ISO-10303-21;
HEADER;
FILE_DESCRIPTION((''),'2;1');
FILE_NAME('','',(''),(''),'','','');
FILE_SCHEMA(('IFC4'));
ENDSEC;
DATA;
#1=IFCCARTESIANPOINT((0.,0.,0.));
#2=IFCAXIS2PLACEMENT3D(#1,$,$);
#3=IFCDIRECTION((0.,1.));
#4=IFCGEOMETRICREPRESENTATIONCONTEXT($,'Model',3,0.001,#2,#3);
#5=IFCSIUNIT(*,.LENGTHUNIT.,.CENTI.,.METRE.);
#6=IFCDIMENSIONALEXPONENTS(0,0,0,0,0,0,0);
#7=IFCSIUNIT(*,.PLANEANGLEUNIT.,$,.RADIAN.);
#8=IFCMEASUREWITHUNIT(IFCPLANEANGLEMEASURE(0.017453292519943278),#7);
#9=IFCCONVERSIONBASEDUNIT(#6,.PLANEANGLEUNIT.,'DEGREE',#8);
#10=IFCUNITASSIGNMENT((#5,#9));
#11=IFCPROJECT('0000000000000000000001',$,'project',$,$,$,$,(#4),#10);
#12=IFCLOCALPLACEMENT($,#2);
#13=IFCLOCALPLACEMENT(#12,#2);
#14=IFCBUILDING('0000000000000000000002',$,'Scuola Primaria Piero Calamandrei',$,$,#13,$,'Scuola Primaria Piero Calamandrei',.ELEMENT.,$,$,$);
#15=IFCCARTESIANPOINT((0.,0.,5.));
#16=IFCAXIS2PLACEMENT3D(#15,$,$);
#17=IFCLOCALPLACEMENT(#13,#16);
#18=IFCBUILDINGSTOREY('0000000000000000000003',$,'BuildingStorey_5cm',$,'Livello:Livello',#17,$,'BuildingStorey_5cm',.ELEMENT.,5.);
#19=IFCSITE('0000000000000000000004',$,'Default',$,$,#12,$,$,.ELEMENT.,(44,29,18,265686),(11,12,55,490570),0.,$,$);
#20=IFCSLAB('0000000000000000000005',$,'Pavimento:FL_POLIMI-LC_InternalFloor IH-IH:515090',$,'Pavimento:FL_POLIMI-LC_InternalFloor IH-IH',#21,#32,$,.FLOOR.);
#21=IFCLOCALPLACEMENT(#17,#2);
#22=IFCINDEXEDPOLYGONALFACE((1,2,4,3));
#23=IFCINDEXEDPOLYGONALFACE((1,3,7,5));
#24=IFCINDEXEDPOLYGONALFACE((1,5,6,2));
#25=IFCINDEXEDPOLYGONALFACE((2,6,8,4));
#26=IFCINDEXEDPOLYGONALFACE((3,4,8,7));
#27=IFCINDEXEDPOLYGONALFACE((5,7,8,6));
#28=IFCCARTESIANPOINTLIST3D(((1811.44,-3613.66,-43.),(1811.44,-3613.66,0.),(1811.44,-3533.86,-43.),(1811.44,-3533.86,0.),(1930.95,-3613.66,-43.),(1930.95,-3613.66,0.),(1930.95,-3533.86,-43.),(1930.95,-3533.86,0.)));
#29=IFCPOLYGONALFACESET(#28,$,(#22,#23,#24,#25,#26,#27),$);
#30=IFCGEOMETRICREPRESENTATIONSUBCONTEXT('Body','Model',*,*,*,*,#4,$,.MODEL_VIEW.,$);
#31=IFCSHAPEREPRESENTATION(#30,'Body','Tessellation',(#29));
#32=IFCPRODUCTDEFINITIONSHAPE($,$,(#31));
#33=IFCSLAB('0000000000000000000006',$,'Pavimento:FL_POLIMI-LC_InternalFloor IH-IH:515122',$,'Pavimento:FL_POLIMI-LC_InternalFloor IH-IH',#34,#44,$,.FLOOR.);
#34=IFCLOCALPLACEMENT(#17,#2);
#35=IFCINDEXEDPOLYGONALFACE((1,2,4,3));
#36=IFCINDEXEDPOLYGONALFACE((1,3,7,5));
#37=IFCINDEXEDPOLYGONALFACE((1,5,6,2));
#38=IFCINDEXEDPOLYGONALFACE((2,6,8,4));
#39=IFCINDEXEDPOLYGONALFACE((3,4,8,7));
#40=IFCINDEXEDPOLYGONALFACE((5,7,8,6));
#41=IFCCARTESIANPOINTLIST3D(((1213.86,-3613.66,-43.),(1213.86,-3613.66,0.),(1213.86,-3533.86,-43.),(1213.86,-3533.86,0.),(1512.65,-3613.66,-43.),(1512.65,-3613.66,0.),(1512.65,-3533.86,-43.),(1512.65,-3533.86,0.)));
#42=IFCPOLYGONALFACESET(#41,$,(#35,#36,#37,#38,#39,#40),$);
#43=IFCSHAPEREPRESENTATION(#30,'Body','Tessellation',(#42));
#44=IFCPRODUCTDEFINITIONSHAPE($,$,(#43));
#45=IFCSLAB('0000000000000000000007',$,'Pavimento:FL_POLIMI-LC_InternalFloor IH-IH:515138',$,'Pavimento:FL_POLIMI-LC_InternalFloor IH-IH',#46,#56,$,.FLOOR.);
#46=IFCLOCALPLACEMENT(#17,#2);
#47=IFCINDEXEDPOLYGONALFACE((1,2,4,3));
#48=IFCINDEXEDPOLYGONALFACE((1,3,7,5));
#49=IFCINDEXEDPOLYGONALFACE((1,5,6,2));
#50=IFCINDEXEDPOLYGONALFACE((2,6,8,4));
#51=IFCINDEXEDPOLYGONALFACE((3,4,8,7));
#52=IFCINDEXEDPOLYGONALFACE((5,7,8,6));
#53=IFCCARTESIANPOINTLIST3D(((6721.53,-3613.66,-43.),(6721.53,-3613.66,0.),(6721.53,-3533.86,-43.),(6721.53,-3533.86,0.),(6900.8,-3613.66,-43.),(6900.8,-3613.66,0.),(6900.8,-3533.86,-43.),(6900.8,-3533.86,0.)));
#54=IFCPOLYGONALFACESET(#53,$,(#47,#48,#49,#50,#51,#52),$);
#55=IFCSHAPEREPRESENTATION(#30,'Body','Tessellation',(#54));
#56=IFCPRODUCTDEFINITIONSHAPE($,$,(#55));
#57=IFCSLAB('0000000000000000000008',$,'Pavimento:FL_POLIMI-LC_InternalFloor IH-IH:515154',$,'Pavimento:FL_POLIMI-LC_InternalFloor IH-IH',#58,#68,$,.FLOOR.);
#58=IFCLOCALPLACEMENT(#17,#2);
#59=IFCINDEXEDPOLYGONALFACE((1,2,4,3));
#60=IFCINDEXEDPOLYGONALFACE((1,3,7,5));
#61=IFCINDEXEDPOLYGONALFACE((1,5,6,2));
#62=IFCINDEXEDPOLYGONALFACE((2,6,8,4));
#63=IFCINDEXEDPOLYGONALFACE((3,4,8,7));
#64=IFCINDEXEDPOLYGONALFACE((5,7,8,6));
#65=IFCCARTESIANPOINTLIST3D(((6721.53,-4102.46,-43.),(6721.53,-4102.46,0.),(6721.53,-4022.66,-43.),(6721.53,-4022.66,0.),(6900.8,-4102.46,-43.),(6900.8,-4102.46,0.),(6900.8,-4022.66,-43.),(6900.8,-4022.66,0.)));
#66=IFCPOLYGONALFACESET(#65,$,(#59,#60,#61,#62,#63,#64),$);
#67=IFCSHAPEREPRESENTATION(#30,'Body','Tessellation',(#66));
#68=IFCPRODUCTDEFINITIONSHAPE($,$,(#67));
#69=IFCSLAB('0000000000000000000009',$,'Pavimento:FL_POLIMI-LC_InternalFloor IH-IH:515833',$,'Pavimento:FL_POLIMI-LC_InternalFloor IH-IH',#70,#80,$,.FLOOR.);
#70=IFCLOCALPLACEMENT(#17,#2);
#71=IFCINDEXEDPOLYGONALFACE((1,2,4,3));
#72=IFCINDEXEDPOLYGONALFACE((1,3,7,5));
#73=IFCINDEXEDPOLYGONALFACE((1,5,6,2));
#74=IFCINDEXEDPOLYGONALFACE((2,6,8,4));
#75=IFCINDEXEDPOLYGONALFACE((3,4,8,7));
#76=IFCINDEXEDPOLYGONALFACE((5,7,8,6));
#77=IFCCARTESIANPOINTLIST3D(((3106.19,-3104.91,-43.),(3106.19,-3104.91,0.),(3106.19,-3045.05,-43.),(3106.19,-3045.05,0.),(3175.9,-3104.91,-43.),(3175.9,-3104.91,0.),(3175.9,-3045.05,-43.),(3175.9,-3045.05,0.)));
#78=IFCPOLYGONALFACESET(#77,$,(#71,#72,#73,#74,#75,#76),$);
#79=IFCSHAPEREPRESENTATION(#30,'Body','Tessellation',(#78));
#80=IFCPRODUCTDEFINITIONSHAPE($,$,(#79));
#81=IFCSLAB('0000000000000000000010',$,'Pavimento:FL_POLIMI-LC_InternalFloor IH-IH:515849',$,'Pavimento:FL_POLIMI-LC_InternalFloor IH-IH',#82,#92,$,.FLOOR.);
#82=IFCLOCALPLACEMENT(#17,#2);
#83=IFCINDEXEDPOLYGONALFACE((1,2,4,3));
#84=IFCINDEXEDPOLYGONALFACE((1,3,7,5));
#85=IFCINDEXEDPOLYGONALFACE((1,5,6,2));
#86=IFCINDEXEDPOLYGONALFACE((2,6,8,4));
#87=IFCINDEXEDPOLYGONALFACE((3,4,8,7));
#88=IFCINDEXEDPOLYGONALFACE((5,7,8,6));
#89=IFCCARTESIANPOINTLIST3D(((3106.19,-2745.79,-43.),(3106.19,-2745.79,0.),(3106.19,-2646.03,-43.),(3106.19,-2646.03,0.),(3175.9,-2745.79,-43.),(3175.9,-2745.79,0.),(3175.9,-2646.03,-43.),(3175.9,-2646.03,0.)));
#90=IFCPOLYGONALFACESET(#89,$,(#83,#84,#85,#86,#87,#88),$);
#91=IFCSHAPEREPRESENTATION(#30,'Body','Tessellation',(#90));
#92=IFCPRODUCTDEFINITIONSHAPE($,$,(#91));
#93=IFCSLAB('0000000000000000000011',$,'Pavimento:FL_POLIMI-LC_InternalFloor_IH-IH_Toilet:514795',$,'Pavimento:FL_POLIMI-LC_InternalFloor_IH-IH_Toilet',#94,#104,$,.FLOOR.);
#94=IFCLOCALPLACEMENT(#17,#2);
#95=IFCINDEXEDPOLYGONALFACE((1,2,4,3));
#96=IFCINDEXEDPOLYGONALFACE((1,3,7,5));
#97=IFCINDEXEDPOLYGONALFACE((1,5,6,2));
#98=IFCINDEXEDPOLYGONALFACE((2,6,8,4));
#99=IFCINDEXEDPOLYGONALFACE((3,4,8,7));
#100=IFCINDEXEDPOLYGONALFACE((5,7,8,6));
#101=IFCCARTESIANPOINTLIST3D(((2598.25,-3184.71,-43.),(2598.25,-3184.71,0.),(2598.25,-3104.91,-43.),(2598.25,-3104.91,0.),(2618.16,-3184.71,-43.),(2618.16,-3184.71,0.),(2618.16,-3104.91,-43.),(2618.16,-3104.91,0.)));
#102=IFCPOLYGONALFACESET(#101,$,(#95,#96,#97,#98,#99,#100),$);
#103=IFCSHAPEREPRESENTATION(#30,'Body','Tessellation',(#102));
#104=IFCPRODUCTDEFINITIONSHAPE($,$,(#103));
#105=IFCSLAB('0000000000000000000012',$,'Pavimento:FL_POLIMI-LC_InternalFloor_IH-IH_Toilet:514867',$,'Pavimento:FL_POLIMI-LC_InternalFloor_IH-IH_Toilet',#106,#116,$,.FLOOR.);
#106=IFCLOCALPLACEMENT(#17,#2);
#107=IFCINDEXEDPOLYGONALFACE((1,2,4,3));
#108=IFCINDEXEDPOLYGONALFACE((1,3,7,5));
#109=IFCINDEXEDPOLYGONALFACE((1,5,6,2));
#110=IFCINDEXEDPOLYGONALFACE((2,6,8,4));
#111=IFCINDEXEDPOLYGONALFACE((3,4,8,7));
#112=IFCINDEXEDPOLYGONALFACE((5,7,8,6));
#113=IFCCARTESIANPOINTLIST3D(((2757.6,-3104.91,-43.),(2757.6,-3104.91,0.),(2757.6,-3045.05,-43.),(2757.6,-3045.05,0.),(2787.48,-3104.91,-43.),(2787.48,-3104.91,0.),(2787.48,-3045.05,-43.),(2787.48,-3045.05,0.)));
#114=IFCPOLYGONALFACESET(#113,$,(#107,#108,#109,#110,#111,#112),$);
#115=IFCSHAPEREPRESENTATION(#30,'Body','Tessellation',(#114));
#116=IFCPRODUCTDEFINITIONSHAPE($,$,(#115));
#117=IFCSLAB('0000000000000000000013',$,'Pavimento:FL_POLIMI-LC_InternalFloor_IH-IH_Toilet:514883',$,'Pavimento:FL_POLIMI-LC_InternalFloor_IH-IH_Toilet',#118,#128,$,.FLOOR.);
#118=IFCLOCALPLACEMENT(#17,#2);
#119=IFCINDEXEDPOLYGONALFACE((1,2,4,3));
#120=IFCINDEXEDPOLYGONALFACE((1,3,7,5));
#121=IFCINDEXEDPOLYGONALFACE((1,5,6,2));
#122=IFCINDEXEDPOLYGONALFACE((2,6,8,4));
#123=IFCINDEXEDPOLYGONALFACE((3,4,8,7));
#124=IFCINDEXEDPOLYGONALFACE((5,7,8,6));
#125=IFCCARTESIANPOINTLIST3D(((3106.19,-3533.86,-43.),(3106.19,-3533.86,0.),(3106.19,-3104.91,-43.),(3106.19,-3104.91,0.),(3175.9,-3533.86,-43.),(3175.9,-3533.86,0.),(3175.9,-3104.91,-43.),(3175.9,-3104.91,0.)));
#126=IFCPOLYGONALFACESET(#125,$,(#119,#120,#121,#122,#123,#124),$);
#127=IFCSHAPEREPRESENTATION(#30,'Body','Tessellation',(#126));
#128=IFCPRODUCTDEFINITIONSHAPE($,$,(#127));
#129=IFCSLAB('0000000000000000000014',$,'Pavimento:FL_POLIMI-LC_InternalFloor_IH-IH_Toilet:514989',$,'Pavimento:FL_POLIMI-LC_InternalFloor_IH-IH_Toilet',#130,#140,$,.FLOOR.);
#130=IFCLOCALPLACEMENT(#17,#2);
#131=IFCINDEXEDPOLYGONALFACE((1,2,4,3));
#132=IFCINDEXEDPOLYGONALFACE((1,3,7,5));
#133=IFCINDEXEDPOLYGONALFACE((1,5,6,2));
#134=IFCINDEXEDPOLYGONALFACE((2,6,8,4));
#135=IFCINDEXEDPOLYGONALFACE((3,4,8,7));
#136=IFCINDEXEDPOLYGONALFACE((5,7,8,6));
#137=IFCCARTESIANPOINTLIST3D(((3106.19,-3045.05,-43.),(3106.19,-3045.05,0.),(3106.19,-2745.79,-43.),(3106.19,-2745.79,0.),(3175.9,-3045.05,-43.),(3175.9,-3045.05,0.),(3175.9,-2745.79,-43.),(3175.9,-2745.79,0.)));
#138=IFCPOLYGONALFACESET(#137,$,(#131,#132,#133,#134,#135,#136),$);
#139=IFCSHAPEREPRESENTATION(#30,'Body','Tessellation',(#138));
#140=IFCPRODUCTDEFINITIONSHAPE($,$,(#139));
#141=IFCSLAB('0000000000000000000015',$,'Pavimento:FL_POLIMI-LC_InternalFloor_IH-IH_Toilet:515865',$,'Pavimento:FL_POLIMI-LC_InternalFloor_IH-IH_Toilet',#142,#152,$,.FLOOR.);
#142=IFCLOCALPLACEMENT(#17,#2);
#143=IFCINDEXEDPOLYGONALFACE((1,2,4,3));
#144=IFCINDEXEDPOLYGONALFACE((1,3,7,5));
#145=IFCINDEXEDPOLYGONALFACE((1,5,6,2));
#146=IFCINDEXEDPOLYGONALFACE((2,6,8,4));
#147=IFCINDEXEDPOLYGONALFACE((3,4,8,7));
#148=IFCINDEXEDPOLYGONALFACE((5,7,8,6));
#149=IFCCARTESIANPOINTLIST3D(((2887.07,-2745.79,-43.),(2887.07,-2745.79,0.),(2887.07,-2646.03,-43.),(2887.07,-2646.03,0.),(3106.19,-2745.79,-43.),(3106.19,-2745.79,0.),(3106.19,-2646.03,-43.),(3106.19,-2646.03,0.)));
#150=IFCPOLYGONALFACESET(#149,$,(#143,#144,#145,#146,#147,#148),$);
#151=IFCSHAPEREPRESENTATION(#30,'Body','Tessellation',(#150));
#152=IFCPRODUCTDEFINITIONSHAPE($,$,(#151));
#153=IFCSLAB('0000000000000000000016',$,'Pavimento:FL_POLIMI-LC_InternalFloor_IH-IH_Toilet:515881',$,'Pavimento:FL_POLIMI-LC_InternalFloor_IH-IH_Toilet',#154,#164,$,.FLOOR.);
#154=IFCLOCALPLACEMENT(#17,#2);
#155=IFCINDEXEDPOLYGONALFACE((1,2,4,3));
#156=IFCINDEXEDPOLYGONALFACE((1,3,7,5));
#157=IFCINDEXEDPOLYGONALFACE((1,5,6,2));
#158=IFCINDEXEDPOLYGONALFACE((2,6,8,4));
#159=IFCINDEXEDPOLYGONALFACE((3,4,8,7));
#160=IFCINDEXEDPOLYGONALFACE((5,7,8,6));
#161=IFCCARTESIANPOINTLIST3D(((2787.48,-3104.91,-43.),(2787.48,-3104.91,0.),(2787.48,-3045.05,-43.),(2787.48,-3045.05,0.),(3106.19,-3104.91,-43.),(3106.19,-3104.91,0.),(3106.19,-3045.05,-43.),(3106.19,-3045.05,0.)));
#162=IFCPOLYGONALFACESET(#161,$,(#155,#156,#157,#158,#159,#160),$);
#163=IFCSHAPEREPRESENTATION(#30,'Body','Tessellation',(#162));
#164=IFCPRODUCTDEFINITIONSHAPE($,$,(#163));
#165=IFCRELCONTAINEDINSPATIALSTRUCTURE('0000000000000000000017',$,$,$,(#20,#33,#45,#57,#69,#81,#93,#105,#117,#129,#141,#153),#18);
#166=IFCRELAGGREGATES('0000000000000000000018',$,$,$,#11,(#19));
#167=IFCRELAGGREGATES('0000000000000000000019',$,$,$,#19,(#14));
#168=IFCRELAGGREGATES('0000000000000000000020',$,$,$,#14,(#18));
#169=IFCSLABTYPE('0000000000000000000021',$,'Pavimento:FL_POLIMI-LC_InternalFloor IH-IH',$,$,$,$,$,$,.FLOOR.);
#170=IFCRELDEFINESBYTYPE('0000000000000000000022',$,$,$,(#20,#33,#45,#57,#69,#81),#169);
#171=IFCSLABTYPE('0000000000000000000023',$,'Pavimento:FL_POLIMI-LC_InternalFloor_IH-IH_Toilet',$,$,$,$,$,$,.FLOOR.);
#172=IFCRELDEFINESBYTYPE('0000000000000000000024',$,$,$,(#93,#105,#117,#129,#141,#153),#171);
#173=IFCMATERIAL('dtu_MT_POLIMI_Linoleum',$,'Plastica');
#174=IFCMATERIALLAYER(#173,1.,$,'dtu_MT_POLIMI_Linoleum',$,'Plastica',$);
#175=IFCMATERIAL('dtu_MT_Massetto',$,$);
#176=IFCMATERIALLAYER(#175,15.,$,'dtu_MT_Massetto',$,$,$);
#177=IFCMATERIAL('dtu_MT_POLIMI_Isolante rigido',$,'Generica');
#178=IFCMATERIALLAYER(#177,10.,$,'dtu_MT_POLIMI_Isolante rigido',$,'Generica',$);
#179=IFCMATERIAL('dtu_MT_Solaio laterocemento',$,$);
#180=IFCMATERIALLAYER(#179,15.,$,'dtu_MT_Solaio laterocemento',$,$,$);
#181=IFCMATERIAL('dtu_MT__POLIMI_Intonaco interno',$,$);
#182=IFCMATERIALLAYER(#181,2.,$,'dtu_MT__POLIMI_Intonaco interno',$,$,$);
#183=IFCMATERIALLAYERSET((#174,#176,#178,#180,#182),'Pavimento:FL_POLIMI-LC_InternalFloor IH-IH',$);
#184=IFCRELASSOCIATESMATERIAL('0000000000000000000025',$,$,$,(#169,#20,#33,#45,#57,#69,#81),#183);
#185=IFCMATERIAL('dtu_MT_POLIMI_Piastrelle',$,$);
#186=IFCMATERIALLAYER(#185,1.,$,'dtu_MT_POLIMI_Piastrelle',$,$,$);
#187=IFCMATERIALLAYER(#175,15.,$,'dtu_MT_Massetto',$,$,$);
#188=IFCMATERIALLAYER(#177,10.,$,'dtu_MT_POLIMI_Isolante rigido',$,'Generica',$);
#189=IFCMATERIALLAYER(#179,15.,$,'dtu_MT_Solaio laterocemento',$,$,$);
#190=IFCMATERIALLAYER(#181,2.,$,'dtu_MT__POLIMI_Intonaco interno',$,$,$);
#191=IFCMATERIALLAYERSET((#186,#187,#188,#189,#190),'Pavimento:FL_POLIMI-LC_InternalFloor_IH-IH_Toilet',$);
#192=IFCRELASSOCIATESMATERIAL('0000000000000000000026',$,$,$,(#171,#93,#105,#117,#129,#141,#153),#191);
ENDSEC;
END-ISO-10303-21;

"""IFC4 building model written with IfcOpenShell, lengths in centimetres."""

from ifc_helpers import new_model, entity, si_unit, converted_unit, direction, frame, frame_2d, origin, origin_2d_with_axis, place, context, subcontext, project, spatial, rectangle, extrude, material, layer, layer_set, layer_usage, type_object, element, save


model = new_model("IFC4")

# Units and contexts
model_context = context("Model", 3, precision=0.001, world=origin(), true_north=direction((0.0, 1.0)))
body_context = subcontext(model_context, "Body", "Model", "MODEL_VIEW")
ifc_project = project(units=[si_unit("LENGTHUNIT", "METRE", prefix="CENTI"), converted_unit("PLANEANGLEUNIT", "DEGREE", entity("IfcPlaneAngleMeasure", 0.017453292519943278), si_unit("PLANEANGLEUNIT", "RADIAN"), dimensions=[0, 0, 0, 0, 0, 0, 0])], contexts=[model_context])

# Site, building, storey
site_placement = place(None, origin())
site = spatial("IfcSite", under=ifc_project, at=site_placement, Name="Default", CompositionType="ELEMENT", RefLatitude=(44, 29, 18, 265686), RefLongitude=(11, 12, 55, 490570), RefElevation=0.0)
building_placement = place(site_placement, origin())
building = spatial("IfcBuilding", under=site, at=building_placement, Name="Scuola Primaria Piero Calamandrei", LongName="Scuola Primaria Piero Calamandrei", CompositionType="ELEMENT")
storey_placement = place(building_placement, frame((0.0, 0.0, 5.0)))
storey = spatial("IfcBuildingStorey", under=building, at=storey_placement, Name="BuildingStorey_5cm", ObjectType="Livello:Livello", LongName="BuildingStorey_5cm", CompositionType="ELEMENT", Elevation=5.0)

# Slabs
ifc_material_1 = material(Name="dtu_MT_POLIMI_Linoleum", Category="Plastica")
ifc_layer_1 = layer(ifc_material_1, 1.0, Name="dtu_MT_POLIMI_Linoleum", Category="Plastica")
ifc_material_2 = material(Name="dtu_MT_Massetto")
ifc_layer_2 = layer(ifc_material_2, 15.0, Name="dtu_MT_Massetto")
ifc_material_3 = material(Name="dtu_MT_POLIMI_Isolante rigido", Category="Generica")
ifc_layer_3 = layer(ifc_material_3, 10.0, Name="dtu_MT_POLIMI_Isolante rigido", Category="Generica")
ifc_material_4 = material(Name="dtu_MT_Solaio laterocemento")
ifc_layer_4 = layer(ifc_material_4, 15.0, Name="dtu_MT_Solaio laterocemento")
ifc_material_5 = material(Name="dtu_MT__POLIMI_Intonaco interno")
ifc_layer_5 = layer(ifc_material_5, 2.0, Name="dtu_MT__POLIMI_Intonaco interno")
ifc_layer_set_1 = layer_set([ifc_layer_1, ifc_layer_2, ifc_layer_3, ifc_layer_4, ifc_layer_5], Name="Pavimento:FL_POLIMI-LC_InternalFloor IH-IH")
slab_type_1 = type_object("IfcSlabType", Name="Pavimento:FL_POLIMI-LC_InternalFloor IH-IH", PredefinedType="FLOOR", material=ifc_layer_set_1)
ifc_layer_usage_1 = layer_usage(ifc_layer_set_1, "AXIS3", "POSITIVE", 0.0)
slab_1_placement = place(storey_placement, origin())
element("IfcSlab", 1, at=slab_1_placement, inside=storey, type_object=slab_type_1, material=ifc_layer_usage_1, Name="Pavimento:FL_POLIMI-LC_InternalFloor IH-IH:515090", ObjectType="Pavimento:FL_POLIMI-LC_InternalFloor IH-IH", PredefinedType="FLOOR", context=body_context, shape_type="SweptSolid", body=[
    extrude(rectangle(XDim=79.8, YDim=119.52, at=origin_2d_with_axis()), frame((1871.19, -3573.76, 0.0), z_axis=(0.0, 0.0, -1.0), x_axis=(0.0, 1.0, 0.0)), (0.0, 0.0, 1.0), 43.0),
])
ifc_layer_usage_2 = layer_usage(ifc_layer_set_1, "AXIS3", "POSITIVE", 0.0)
slab_2_placement = place(storey_placement, origin())
element("IfcSlab", 2, at=slab_2_placement, inside=storey, type_object=slab_type_1, material=ifc_layer_usage_2, Name="Pavimento:FL_POLIMI-LC_InternalFloor IH-IH:515122", ObjectType="Pavimento:FL_POLIMI-LC_InternalFloor IH-IH", PredefinedType="FLOOR", context=body_context, shape_type="SweptSolid", body=[
    extrude(rectangle(XDim=79.8, YDim=298.79, at=frame_2d((0.0, 0.0), x_axis=(1.0, 0.0))), frame((1363.25, -3573.76, 0.0), z_axis=(0.0, 0.0, -1.0), x_axis=(0.0, 1.0, 0.0)), (0.0, 0.0, 1.0), 43.0),
])
ifc_layer_usage_3 = layer_usage(ifc_layer_set_1, "AXIS3", "POSITIVE", 0.0)
slab_3_placement = place(storey_placement, origin())
element("IfcSlab", 3, at=slab_3_placement, inside=storey, type_object=slab_type_1, material=ifc_layer_usage_3, Name="Pavimento:FL_POLIMI-LC_InternalFloor IH-IH:515138", ObjectType="Pavimento:FL_POLIMI-LC_InternalFloor IH-IH", PredefinedType="FLOOR", context=body_context, shape_type="SweptSolid", body=[
    extrude(rectangle(XDim=79.8, YDim=179.27, at=frame_2d((0.0, 0.0), x_axis=(1.0, 0.0))), frame((6811.16, -3573.76, 0.0), z_axis=(0.0, 0.0, -1.0), x_axis=(0.0, 1.0, 0.0)), (0.0, 0.0, 1.0), 43.0),
])
ifc_layer_usage_4 = layer_usage(ifc_layer_set_1, "AXIS3", "POSITIVE", 0.0)
slab_4_placement = place(storey_placement, origin())
element("IfcSlab", 4, at=slab_4_placement, inside=storey, type_object=slab_type_1, material=ifc_layer_usage_4, Name="Pavimento:FL_POLIMI-LC_InternalFloor IH-IH:515154", ObjectType="Pavimento:FL_POLIMI-LC_InternalFloor IH-IH", PredefinedType="FLOOR", context=body_context, shape_type="SweptSolid", body=[
    extrude(rectangle(XDim=79.8, YDim=179.27, at=frame_2d((0.0, 0.0), x_axis=(1.0, 0.0))), frame((6811.16, -4062.56, 0.0), z_axis=(0.0, 0.0, -1.0), x_axis=(0.0, 1.0, 0.0)), (0.0, 0.0, 1.0), 43.0),
])
ifc_layer_usage_5 = layer_usage(ifc_layer_set_1, "AXIS3", "POSITIVE", 0.0)
slab_5_placement = place(storey_placement, origin())
element("IfcSlab", 5, at=slab_5_placement, inside=storey, type_object=slab_type_1, material=ifc_layer_usage_5, Name="Pavimento:FL_POLIMI-LC_InternalFloor IH-IH:515833", ObjectType="Pavimento:FL_POLIMI-LC_InternalFloor IH-IH", PredefinedType="FLOOR", context=body_context, shape_type="SweptSolid", body=[
    extrude(rectangle(XDim=59.85, YDim=69.72, at=frame_2d((0.0, 0.0), x_axis=(1.0, 0.0))), frame((3141.04, -3074.98, 0.0), z_axis=(0.0, 0.0, -1.0), x_axis=(0.0, 1.0, 0.0)), (0.0, 0.0, 1.0), 43.0),
])
ifc_layer_usage_6 = layer_usage(ifc_layer_set_1, "AXIS3", "POSITIVE", 0.0)
slab_6_placement = place(storey_placement, origin())
element("IfcSlab", 6, at=slab_6_placement, inside=storey, type_object=slab_type_1, material=ifc_layer_usage_6, Name="Pavimento:FL_POLIMI-LC_InternalFloor IH-IH:515849", ObjectType="Pavimento:FL_POLIMI-LC_InternalFloor IH-IH", PredefinedType="FLOOR", context=body_context, shape_type="SweptSolid", body=[
    extrude(rectangle(XDim=99.76, YDim=69.72, at=origin_2d_with_axis()), frame((3141.04, -2695.91, 0.0), z_axis=(0.0, 0.0, -1.0), x_axis=(0.0, 1.0, 0.0)), (0.0, 0.0, 1.0), 43.0),
])
ifc_material_6 = material(Name="dtu_MT_POLIMI_Piastrelle")
ifc_layer_6 = layer(ifc_material_6, 1.0, Name="dtu_MT_POLIMI_Piastrelle")
ifc_layer_7 = layer(ifc_material_2, 15.0, Name="dtu_MT_Massetto")
ifc_layer_8 = layer(ifc_material_3, 10.0, Name="dtu_MT_POLIMI_Isolante rigido", Category="Generica")
ifc_layer_9 = layer(ifc_material_4, 15.0, Name="dtu_MT_Solaio laterocemento")
ifc_layer_10 = layer(ifc_material_5, 2.0, Name="dtu_MT__POLIMI_Intonaco interno")
ifc_layer_set_2 = layer_set([ifc_layer_6, ifc_layer_7, ifc_layer_8, ifc_layer_9, ifc_layer_10], Name="Pavimento:FL_POLIMI-LC_InternalFloor_IH-IH_Toilet")
ifc_layer_usage_7 = layer_usage(ifc_layer_set_2, "AXIS3", "POSITIVE", 0.0)
slab_type_2 = type_object("IfcSlabType", Name="Pavimento:FL_POLIMI-LC_InternalFloor_IH-IH_Toilet", PredefinedType="FLOOR", material=ifc_layer_set_2)
slab_7_placement = place(storey_placement, origin())
element("IfcSlab", 7, at=slab_7_placement, inside=storey, type_object=slab_type_2, material=ifc_layer_usage_7, Name="Pavimento:FL_POLIMI-LC_InternalFloor_IH-IH_Toilet:514795", ObjectType="Pavimento:FL_POLIMI-LC_InternalFloor_IH-IH_Toilet", PredefinedType="FLOOR", context=body_context, shape_type="SweptSolid", body=[
    extrude(rectangle(XDim=79.8, YDim=19.92, at=frame_2d((0.0, 0.0), x_axis=(1.0, 0.0))), frame((2608.21, -3144.81, 0.0), z_axis=(0.0, 0.0, -1.0), x_axis=(0.0, 1.0, 0.0)), (0.0, 0.0, 1.0), 43.0),
])
ifc_layer_usage_8 = layer_usage(ifc_layer_set_2, "AXIS3", "POSITIVE", 0.0)
slab_8_placement = place(storey_placement, origin())
element("IfcSlab", 8, at=slab_8_placement, inside=storey, type_object=slab_type_2, material=ifc_layer_usage_8, Name="Pavimento:FL_POLIMI-LC_InternalFloor_IH-IH_Toilet:514867", ObjectType="Pavimento:FL_POLIMI-LC_InternalFloor_IH-IH_Toilet", PredefinedType="FLOOR", context=body_context, shape_type="SweptSolid", body=[
    extrude(rectangle(XDim=59.85, YDim=29.88, at=frame_2d((0.0, 0.0), x_axis=(1.0, 0.0))), frame((2772.54, -3074.98, 0.0), z_axis=(0.0, 0.0, -1.0), x_axis=(0.0, 1.0, 0.0)), (0.0, 0.0, 1.0), 43.0),
])
ifc_layer_usage_9 = layer_usage(ifc_layer_set_2, "AXIS3", "POSITIVE", 0.0)
slab_9_placement = place(storey_placement, origin())
element("IfcSlab", 9, at=slab_9_placement, inside=storey, type_object=slab_type_2, material=ifc_layer_usage_9, Name="Pavimento:FL_POLIMI-LC_InternalFloor_IH-IH_Toilet:514883", ObjectType="Pavimento:FL_POLIMI-LC_InternalFloor_IH-IH_Toilet", PredefinedType="FLOOR", context=body_context, shape_type="SweptSolid", body=[
    extrude(rectangle(XDim=428.95, YDim=69.72, at=frame_2d((0.0, 0.0), x_axis=(1.0, 0.0))), frame((3141.04, -3319.38, 0.0), z_axis=(0.0, 0.0, -1.0), x_axis=(0.0, 1.0, 0.0)), (0.0, 0.0, 1.0), 43.0),
])
ifc_layer_usage_10 = layer_usage(ifc_layer_set_2, "AXIS3", "POSITIVE", 0.0)
slab_10_placement = place(storey_placement, origin())
element("IfcSlab", 10, at=slab_10_placement, inside=storey, type_object=slab_type_2, material=ifc_layer_usage_10, Name="Pavimento:FL_POLIMI-LC_InternalFloor_IH-IH_Toilet:514989", ObjectType="Pavimento:FL_POLIMI-LC_InternalFloor_IH-IH_Toilet", PredefinedType="FLOOR", context=body_context, shape_type="SweptSolid", body=[
    extrude(rectangle(XDim=299.27, YDim=69.72, at=frame_2d((0.0, 0.0), x_axis=(1.0, 0.0))), frame((3141.04, -2895.42, 0.0), z_axis=(0.0, 0.0, -1.0), x_axis=(0.0, 1.0, 0.0)), (0.0, 0.0, 1.0), 43.0),
])
ifc_layer_usage_11 = layer_usage(ifc_layer_set_2, "AXIS3", "POSITIVE", 0.0)
slab_11_placement = place(storey_placement, origin())
element("IfcSlab", 11, at=slab_11_placement, inside=storey, type_object=slab_type_2, material=ifc_layer_usage_11, Name="Pavimento:FL_POLIMI-LC_InternalFloor_IH-IH_Toilet:515865", ObjectType="Pavimento:FL_POLIMI-LC_InternalFloor_IH-IH_Toilet", PredefinedType="FLOOR", context=body_context, shape_type="SweptSolid", body=[
    extrude(rectangle(XDim=99.76, YDim=219.11, at=origin_2d_with_axis()), frame((2996.63, -2695.91, 0.0), z_axis=(0.0, 0.0, -1.0), x_axis=(0.0, 1.0, 0.0)), (0.0, 0.0, 1.0), 43.0),
])
ifc_layer_usage_12 = layer_usage(ifc_layer_set_2, "AXIS3", "POSITIVE", 0.0)
slab_12_placement = place(storey_placement, origin())
element("IfcSlab", 12, at=slab_12_placement, inside=storey, type_object=slab_type_2, material=ifc_layer_usage_12, Name="Pavimento:FL_POLIMI-LC_InternalFloor_IH-IH_Toilet:515881", ObjectType="Pavimento:FL_POLIMI-LC_InternalFloor_IH-IH_Toilet", PredefinedType="FLOOR", context=body_context, shape_type="SweptSolid", body=[
    extrude(rectangle(XDim=59.85, YDim=318.71, at=frame_2d((0.0, 0.0), x_axis=(1.0, 0.0))), frame((2946.83, -3074.98, 0.0), z_axis=(0.0, 0.0, -1.0), x_axis=(0.0, 1.0, 0.0)), (0.0, 0.0, 1.0), 43.0),
])

save(model, "model.ifc")
